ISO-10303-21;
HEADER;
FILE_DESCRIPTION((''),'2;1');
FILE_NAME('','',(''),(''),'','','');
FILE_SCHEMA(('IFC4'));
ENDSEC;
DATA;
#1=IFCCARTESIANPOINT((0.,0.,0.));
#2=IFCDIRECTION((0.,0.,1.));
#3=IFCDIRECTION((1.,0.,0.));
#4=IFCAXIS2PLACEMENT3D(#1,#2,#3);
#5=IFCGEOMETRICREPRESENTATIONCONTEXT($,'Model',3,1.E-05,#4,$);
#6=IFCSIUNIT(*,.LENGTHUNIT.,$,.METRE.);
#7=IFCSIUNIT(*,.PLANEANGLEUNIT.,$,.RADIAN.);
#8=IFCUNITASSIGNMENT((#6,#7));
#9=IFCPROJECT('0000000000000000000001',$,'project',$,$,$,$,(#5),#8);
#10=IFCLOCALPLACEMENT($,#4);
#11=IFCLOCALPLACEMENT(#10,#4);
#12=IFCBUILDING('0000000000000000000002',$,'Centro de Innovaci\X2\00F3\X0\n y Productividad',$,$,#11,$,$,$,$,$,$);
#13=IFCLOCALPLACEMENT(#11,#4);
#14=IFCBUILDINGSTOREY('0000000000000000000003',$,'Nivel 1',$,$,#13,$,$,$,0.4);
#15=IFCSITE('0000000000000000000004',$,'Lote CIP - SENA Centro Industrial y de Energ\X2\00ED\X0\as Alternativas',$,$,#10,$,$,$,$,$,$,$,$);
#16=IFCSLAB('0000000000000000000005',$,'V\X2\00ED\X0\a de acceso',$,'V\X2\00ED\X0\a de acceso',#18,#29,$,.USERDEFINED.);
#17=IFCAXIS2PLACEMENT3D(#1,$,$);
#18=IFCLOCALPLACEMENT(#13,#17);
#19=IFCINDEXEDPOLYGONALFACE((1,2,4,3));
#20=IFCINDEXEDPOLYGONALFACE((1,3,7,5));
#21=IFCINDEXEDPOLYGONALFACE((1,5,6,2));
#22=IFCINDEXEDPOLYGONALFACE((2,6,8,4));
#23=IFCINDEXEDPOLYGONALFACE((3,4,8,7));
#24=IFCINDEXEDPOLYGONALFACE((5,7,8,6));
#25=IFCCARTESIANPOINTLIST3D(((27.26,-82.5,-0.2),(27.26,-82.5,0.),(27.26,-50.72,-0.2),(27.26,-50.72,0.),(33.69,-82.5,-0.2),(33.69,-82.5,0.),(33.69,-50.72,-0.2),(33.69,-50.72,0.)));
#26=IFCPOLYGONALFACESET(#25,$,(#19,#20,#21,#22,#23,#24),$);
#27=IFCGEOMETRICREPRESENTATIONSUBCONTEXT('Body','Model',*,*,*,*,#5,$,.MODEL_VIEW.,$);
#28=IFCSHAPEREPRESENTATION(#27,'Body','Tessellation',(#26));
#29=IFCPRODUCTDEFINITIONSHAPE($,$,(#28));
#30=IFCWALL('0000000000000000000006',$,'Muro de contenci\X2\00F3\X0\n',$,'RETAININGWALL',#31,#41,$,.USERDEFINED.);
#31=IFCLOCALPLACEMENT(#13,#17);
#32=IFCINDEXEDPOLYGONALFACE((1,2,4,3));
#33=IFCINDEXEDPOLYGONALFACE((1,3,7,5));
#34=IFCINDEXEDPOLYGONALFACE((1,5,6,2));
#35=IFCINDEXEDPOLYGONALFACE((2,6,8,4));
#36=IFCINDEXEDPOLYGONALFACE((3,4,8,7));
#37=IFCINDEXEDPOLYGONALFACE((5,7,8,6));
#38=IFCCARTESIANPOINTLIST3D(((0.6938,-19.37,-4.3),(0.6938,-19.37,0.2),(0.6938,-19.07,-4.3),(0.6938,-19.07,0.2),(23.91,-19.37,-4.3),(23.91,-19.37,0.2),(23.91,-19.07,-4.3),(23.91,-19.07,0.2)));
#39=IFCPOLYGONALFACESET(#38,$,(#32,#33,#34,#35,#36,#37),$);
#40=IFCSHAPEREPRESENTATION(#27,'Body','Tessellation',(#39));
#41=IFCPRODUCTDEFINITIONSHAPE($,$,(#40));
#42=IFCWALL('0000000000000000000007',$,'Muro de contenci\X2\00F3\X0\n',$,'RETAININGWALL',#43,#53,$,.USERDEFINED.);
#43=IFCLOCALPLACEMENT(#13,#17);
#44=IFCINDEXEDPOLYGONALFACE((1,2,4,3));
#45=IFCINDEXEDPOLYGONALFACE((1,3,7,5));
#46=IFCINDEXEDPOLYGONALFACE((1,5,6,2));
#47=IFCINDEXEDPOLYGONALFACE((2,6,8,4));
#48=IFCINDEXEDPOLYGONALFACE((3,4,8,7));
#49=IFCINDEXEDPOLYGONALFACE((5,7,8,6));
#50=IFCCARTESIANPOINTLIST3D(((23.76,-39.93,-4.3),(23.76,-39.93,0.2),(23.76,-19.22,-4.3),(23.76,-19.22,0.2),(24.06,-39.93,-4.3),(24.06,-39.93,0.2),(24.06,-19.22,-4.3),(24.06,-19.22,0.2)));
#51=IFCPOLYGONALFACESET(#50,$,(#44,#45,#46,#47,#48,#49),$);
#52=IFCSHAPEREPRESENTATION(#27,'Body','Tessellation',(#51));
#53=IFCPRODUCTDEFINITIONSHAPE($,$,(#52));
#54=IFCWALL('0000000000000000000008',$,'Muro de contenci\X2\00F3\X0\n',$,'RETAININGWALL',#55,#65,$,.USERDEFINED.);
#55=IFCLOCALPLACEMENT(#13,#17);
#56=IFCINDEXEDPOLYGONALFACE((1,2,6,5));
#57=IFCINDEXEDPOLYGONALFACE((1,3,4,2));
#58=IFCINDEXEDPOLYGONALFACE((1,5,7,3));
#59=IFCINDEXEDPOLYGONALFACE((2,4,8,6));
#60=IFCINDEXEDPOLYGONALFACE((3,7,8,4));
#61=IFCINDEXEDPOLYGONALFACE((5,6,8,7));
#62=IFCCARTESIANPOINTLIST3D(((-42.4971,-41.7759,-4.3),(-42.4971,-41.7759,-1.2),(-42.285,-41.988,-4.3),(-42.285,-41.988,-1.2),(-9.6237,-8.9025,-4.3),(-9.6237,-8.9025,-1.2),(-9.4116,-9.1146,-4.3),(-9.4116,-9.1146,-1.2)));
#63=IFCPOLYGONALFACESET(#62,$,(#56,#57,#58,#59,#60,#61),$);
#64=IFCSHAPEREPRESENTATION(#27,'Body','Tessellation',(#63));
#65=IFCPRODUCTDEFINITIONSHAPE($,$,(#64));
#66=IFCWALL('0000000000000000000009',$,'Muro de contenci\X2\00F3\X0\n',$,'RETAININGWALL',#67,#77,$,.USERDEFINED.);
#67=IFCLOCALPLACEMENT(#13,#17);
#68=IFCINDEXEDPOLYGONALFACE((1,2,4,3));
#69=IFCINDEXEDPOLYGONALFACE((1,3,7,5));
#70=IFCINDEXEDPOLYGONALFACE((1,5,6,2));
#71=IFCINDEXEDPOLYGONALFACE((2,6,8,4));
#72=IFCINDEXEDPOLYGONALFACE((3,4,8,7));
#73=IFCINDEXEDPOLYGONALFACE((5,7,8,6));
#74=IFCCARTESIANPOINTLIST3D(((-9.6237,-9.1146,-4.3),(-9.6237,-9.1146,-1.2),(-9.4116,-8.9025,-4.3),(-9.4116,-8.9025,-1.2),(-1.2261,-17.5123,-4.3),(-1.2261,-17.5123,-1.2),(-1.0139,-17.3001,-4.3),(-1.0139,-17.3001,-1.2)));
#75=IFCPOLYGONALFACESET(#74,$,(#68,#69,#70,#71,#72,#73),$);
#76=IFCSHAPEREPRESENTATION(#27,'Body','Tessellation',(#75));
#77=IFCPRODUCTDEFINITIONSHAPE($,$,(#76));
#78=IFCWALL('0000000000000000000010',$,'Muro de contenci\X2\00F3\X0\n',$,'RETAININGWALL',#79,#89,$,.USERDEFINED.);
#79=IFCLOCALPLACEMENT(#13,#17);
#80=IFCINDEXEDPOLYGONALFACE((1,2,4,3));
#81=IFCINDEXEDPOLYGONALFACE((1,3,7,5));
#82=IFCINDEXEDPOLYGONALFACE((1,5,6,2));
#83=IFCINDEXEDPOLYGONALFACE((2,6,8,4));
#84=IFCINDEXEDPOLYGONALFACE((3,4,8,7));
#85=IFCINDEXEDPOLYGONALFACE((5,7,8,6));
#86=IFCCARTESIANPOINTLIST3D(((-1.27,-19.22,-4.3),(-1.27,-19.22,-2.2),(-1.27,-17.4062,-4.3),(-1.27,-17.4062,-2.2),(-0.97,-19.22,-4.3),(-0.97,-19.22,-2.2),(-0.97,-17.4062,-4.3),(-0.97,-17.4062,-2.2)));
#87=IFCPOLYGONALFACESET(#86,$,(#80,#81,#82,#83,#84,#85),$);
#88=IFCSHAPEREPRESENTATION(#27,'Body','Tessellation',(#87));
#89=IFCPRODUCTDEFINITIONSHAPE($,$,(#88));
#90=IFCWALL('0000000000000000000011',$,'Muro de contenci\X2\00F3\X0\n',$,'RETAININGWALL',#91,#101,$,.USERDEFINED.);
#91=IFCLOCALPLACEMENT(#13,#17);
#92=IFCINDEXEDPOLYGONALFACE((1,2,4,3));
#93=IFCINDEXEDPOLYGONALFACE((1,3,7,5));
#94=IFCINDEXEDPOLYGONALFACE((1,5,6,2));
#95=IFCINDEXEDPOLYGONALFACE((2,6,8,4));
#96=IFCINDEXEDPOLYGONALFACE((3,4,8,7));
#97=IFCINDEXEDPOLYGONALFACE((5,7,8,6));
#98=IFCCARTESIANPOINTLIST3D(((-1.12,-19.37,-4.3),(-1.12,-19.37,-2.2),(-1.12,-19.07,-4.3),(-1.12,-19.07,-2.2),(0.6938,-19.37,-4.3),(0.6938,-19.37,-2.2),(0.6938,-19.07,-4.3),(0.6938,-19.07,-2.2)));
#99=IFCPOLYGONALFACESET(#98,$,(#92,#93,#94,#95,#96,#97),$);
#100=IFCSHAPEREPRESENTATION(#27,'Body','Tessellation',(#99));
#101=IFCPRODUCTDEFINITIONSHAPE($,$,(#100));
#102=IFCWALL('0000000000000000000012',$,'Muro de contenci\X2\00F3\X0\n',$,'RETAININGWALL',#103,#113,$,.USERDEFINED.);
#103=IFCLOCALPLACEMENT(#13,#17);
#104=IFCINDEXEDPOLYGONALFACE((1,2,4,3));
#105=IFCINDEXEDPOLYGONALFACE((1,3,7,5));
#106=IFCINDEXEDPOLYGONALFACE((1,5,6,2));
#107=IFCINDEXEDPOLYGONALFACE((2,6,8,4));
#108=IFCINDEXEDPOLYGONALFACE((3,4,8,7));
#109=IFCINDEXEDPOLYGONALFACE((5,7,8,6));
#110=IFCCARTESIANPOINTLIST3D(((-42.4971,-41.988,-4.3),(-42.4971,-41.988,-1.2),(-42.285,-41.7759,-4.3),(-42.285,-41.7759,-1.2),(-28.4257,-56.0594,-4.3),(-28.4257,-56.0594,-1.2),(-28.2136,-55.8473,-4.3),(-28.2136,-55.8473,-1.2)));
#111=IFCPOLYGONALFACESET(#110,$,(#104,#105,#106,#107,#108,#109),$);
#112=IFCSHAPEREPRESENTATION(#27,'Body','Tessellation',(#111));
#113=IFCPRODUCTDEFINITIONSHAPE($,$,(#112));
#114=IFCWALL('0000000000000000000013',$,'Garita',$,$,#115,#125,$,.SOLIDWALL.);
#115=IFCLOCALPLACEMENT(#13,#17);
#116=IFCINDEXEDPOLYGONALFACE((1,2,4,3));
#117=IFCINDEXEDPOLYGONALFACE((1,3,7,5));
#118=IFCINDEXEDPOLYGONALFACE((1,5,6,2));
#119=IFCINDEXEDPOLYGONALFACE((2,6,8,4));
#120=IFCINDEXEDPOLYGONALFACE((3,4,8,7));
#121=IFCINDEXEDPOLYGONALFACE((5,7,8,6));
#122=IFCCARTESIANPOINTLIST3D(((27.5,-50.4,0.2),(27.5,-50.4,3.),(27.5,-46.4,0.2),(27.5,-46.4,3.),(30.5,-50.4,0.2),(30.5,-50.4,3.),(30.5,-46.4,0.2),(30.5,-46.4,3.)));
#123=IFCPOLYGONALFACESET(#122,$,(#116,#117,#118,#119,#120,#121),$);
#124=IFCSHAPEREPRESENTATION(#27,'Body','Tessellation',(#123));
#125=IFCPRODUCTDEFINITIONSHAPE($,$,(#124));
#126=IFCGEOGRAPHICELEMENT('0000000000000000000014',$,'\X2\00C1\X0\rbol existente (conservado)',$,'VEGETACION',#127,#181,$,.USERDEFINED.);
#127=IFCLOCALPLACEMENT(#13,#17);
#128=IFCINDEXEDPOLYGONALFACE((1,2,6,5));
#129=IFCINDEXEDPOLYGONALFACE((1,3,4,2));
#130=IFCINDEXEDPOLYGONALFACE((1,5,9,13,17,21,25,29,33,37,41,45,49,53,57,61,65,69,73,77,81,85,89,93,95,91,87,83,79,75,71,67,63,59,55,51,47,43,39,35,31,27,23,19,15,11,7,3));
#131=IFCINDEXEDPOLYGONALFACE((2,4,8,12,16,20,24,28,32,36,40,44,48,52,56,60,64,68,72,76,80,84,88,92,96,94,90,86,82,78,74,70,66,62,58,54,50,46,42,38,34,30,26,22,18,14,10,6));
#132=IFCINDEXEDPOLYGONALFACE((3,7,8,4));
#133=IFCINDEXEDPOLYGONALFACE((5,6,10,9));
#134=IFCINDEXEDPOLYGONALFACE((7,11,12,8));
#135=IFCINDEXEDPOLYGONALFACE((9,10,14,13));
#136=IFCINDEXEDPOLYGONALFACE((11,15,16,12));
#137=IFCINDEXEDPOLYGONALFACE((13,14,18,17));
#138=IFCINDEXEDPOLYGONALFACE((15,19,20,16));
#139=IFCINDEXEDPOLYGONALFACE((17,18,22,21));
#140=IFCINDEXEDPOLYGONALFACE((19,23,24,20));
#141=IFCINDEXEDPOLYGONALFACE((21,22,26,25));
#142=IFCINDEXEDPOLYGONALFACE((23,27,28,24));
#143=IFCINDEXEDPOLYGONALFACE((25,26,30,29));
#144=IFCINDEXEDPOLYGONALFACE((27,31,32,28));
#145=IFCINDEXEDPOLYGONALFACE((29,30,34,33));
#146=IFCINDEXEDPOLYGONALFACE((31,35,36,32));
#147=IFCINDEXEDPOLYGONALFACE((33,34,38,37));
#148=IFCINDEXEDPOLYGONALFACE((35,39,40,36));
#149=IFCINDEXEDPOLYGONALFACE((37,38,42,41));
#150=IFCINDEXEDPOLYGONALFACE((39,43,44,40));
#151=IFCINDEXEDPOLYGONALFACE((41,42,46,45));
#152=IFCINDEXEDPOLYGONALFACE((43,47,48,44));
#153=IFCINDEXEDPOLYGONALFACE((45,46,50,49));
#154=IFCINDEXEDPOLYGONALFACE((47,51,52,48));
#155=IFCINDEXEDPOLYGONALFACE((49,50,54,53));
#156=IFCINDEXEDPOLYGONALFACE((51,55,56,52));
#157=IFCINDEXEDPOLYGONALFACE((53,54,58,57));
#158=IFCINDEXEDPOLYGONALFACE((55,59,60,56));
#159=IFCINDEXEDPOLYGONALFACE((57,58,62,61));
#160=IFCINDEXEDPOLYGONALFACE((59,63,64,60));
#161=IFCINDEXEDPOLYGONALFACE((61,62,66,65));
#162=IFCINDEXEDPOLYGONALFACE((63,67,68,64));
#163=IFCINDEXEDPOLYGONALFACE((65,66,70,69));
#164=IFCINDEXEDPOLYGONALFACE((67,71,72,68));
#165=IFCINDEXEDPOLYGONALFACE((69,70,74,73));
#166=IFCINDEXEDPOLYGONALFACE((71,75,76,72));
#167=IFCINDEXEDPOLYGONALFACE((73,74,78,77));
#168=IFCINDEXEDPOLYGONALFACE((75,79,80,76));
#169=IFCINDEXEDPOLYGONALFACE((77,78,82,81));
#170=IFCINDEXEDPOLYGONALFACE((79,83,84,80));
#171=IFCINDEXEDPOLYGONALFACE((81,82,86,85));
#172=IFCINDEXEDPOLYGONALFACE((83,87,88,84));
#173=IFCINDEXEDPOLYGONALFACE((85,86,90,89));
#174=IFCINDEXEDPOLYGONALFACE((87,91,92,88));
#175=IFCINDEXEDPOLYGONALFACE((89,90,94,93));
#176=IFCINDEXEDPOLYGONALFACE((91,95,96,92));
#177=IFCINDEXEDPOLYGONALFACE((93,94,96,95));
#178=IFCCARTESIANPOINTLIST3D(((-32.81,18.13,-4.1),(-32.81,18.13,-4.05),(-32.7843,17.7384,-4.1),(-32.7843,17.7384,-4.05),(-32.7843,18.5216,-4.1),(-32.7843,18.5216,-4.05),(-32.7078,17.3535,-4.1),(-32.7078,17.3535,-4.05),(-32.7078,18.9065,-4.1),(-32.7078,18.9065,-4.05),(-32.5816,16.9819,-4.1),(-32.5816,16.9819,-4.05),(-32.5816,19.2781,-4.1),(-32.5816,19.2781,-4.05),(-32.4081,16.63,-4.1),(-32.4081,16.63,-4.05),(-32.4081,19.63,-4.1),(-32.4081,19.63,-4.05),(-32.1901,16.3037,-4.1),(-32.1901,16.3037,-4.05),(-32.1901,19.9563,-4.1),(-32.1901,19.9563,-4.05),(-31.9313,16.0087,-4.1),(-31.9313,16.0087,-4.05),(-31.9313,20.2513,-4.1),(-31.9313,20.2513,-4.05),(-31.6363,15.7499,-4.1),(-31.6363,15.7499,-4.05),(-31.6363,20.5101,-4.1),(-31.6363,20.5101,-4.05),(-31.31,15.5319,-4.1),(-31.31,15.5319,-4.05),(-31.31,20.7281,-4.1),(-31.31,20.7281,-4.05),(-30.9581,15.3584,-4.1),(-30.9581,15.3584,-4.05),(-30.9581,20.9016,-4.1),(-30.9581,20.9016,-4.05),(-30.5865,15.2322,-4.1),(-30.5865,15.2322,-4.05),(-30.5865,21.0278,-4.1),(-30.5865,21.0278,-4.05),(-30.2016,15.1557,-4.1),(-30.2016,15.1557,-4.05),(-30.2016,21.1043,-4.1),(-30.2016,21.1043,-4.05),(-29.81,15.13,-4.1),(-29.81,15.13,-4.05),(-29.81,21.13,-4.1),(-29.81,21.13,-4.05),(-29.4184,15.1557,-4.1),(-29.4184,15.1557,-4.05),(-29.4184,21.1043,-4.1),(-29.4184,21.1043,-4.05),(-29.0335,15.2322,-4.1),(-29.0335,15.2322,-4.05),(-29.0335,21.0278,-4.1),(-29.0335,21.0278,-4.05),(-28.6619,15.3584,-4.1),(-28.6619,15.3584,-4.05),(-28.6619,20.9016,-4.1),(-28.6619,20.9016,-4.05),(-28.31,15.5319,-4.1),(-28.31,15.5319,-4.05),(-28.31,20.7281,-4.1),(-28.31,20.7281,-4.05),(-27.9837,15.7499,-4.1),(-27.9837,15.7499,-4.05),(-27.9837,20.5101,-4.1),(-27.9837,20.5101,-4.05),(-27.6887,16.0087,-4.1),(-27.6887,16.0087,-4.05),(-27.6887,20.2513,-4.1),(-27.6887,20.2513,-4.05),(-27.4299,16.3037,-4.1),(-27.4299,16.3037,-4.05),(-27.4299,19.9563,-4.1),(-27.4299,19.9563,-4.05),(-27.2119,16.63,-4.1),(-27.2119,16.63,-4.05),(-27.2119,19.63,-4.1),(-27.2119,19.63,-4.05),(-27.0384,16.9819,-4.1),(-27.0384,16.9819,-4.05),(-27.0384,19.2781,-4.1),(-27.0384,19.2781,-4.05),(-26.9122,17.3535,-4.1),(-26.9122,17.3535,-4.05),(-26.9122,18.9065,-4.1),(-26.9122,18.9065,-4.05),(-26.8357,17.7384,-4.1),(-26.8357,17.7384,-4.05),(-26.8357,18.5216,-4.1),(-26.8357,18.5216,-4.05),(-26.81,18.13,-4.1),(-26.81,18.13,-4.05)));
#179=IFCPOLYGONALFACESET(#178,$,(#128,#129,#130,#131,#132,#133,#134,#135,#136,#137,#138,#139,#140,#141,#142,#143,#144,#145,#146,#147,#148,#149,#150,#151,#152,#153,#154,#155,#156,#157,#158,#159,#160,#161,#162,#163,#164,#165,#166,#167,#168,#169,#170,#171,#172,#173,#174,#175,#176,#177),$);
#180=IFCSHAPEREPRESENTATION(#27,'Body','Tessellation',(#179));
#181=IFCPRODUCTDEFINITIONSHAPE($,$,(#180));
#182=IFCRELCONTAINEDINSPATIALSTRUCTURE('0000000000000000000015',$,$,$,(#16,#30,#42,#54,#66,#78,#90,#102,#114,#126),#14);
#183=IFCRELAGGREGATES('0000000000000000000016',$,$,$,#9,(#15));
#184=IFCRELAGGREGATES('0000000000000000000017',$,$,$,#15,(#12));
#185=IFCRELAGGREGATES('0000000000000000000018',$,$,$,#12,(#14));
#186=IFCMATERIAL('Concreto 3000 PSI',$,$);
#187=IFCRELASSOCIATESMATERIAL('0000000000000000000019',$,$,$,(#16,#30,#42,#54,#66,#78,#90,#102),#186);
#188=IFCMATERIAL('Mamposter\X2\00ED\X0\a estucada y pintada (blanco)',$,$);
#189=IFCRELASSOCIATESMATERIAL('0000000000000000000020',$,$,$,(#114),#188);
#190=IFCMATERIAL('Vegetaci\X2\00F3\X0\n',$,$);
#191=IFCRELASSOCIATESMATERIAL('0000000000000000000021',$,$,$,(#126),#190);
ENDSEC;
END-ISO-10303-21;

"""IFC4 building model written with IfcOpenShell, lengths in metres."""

from ifc_helpers import new_model, si_unit, frame, origin_with_axes, place, context, subcontext, project, spatial, polyline, outline, extrude, material, element, save


model = new_model("IFC4")

# Units and contexts
model_context = context("Model", 3, precision=1e-05, world=origin_with_axes())
body_context = subcontext(model_context, "Body", "Model", "MODEL_VIEW")
ifc_project = project(units=[si_unit("LENGTHUNIT", "METRE"), si_unit("PLANEANGLEUNIT", "RADIAN")], contexts=[model_context])

# Site, building, storey
site_placement = place(None, origin_with_axes())
site = spatial("IfcSite", under=ifc_project, at=site_placement, Name="Lote CIP - SENA Centro Industrial y de Energías Alternativas")
building_placement = place(site_placement, origin_with_axes())
building = spatial("IfcBuilding", under=site, at=building_placement, Name="Centro de Innovación y Productividad")
storey_placement = place(building_placement, origin_with_axes())
storey = spatial("IfcBuildingStorey", under=building, at=storey_placement, Name="Nivel 1", Elevation=0.4)

# Slab
ifc_material_1 = material(Name="Concreto 3000 PSI")
slab_placement = place(storey_placement, origin_with_axes())
element("IfcSlab", 1, at=slab_placement, inside=storey, material=ifc_material_1, Name="Vía de acceso", ObjectType="Vía de acceso", PredefinedType="USERDEFINED", context=body_context, shape_type="SweptSolid", body=[
    extrude(outline(polyline([(33.69, -82.5), (27.26, -82.5), (27.26, -50.72), (33.69, -50.72), (33.69, -82.5)])), frame((0.0, 0.0, -0.2)), (0.0, 0.0, 1.0), 0.2),
])

# Walls
wall_1_placement = place(storey_placement, origin_with_axes())
element("IfcWall", 2, at=wall_1_placement, inside=storey, material=ifc_material_1, Name="Muro de contención", ObjectType="RETAININGWALL", PredefinedType="USERDEFINED", context=body_context, shape_type="SweptSolid", body=[
    extrude(outline(polyline([(23.91, -19.07), (23.91, -19.37), (0.6938, -19.37), (0.6938, -19.07), (23.91, -19.07)])), frame((0.0, 0.0, -4.3)), (0.0, 0.0, 1.0), 4.5),
])
wall_2_placement = place(storey_placement, origin_with_axes())
element("IfcWall", 3, at=wall_2_placement, inside=storey, material=ifc_material_1, Name="Muro de contención", ObjectType="RETAININGWALL", PredefinedType="USERDEFINED", context=body_context, shape_type="SweptSolid", body=[
    extrude(outline(polyline([(24.06, -39.93), (23.76, -39.93), (23.76, -19.22), (24.06, -19.22), (24.06, -39.93)])), frame((0.0, 0.0, -4.3)), (0.0, 0.0, 1.0), 4.5),
])
wall_3_placement = place(storey_placement, origin_with_axes())
element("IfcWall", 4, at=wall_3_placement, inside=storey, material=ifc_material_1, Name="Muro de contención", ObjectType="RETAININGWALL", PredefinedType="USERDEFINED", context=body_context, shape_type="SweptSolid", body=[
    extrude(outline(polyline([(-9.6237, -8.9025), (-9.4116, -9.1146), (-42.285, -41.988), (-42.4971, -41.7759), (-9.6237, -8.9025)])), frame((0.0, 0.0, -4.3)), (0.0, 0.0, 1.0), 3.1),
])
wall_4_placement = place(storey_placement, origin_with_axes())
element("IfcWall", 5, at=wall_4_placement, inside=storey, material=ifc_material_1, Name="Muro de contención", ObjectType="RETAININGWALL", PredefinedType="USERDEFINED", context=body_context, shape_type="SweptSolid", body=[
    extrude(outline(polyline([(-1.0139, -17.3001), (-1.2261, -17.5123), (-9.6237, -9.1146), (-9.4116, -8.9025), (-1.0139, -17.3001)])), frame((0.0, 0.0, -4.3)), (0.0, 0.0, 1.0), 3.1),
])
wall_5_placement = place(storey_placement, origin_with_axes())
element("IfcWall", 6, at=wall_5_placement, inside=storey, material=ifc_material_1, Name="Muro de contención", ObjectType="RETAININGWALL", PredefinedType="USERDEFINED", context=body_context, shape_type="SweptSolid", body=[
    extrude(outline(polyline([(-0.97, -19.22), (-1.27, -19.22), (-1.27, -17.4062), (-0.97, -17.4062), (-0.97, -19.22)])), frame((0.0, 0.0, -4.3)), (0.0, 0.0, 1.0), 2.1),
])
wall_6_placement = place(storey_placement, origin_with_axes())
element("IfcWall", 7, at=wall_6_placement, inside=storey, material=ifc_material_1, Name="Muro de contención", ObjectType="RETAININGWALL", PredefinedType="USERDEFINED", context=body_context, shape_type="SweptSolid", body=[
    extrude(outline(polyline([(0.6938, -19.07), (0.6938, -19.37), (-1.12, -19.37), (-1.12, -19.07), (0.6938, -19.07)])), frame((0.0, 0.0, -4.3)), (0.0, 0.0, 1.0), 2.1),
])
wall_7_placement = place(storey_placement, origin_with_axes())
element("IfcWall", 8, at=wall_7_placement, inside=storey, material=ifc_material_1, Name="Muro de contención", ObjectType="RETAININGWALL", PredefinedType="USERDEFINED", context=body_context, shape_type="SweptSolid", body=[
    extrude(outline(polyline([(-42.4971, -41.988), (-42.285, -41.7759), (-28.2136, -55.8473), (-28.4257, -56.0594), (-42.4971, -41.988)])), frame((0.0, 0.0, -4.3)), (0.0, 0.0, 1.0), 3.1),
])
ifc_material_2 = material(Name="Mampostería estucada y pintada (blanco)")
wall_8_placement = place(storey_placement, origin_with_axes())
element("IfcWall", 9, at=wall_8_placement, inside=storey, material=ifc_material_2, Name="Garita", PredefinedType="SOLIDWALL", context=body_context, shape_type="SweptSolid", body=[
    extrude(outline(polyline([(30.5, -50.4), (27.5, -50.4), (27.5, -46.4), (30.5, -46.4), (30.5, -50.4)])), frame((0.0, 0.0, 0.2)), (0.0, 0.0, 1.0), 2.8),
])

# Geographic element
ifc_material_3 = material(Name="Vegetación")
geographic_element_1_placement = place(storey_placement, origin_with_axes())
element("IfcGeographicElement", 10, at=geographic_element_1_placement, inside=storey, material=ifc_material_3, Name="Árbol existente (conservado)", ObjectType="VEGETACION", PredefinedType="USERDEFINED", context=body_context, shape_type="SweptSolid", body=[
    extrude(outline(polyline([(-26.81, 18.13), (-26.8357, 17.7384), (-26.9122, 17.3535), (-27.0384, 16.9819), (-27.2119, 16.63), (-27.4299, 16.3037), (-27.6887, 16.0087), (-27.9837, 15.7499), (-28.31, 15.5319), (-28.6619, 15.3584), (-29.0335, 15.2322), (-29.4184, 15.1557), (-29.81, 15.13), (-30.2016, 15.1557), (-30.5865, 15.2322), (-30.9581, 15.3584), (-31.31, 15.5319), (-31.6363, 15.7499), (-31.9313, 16.0087), (-32.1901, 16.3037), (-32.4081, 16.63), (-32.5816, 16.9819), (-32.7078, 17.3535), (-32.7843, 17.7384), (-32.81, 18.13), (-32.7843, 18.5216), (-32.7078, 18.9065), (-32.5816, 19.2781), (-32.4081, 19.63), (-32.1901, 19.9563), (-31.9313, 20.2513), (-31.6363, 20.5101), (-31.31, 20.7281), (-30.9581, 20.9016), (-30.5865, 21.0278), (-30.2016, 21.1043), (-29.81, 21.13), (-29.4184, 21.1043), (-29.0335, 21.0278), (-28.6619, 20.9016), (-28.31, 20.7281), (-27.9837, 20.5101), (-27.6887, 20.2513), (-27.4299, 19.9563), (-27.2119, 19.63), (-27.0384, 19.2781), (-26.9122, 18.9065), (-26.8357, 18.5216), (-26.81, 18.13)])), frame((0.0, 0.0, -4.1)), (0.0, 0.0, 1.0), 0.05),
])

save(model, "model.ifc")
